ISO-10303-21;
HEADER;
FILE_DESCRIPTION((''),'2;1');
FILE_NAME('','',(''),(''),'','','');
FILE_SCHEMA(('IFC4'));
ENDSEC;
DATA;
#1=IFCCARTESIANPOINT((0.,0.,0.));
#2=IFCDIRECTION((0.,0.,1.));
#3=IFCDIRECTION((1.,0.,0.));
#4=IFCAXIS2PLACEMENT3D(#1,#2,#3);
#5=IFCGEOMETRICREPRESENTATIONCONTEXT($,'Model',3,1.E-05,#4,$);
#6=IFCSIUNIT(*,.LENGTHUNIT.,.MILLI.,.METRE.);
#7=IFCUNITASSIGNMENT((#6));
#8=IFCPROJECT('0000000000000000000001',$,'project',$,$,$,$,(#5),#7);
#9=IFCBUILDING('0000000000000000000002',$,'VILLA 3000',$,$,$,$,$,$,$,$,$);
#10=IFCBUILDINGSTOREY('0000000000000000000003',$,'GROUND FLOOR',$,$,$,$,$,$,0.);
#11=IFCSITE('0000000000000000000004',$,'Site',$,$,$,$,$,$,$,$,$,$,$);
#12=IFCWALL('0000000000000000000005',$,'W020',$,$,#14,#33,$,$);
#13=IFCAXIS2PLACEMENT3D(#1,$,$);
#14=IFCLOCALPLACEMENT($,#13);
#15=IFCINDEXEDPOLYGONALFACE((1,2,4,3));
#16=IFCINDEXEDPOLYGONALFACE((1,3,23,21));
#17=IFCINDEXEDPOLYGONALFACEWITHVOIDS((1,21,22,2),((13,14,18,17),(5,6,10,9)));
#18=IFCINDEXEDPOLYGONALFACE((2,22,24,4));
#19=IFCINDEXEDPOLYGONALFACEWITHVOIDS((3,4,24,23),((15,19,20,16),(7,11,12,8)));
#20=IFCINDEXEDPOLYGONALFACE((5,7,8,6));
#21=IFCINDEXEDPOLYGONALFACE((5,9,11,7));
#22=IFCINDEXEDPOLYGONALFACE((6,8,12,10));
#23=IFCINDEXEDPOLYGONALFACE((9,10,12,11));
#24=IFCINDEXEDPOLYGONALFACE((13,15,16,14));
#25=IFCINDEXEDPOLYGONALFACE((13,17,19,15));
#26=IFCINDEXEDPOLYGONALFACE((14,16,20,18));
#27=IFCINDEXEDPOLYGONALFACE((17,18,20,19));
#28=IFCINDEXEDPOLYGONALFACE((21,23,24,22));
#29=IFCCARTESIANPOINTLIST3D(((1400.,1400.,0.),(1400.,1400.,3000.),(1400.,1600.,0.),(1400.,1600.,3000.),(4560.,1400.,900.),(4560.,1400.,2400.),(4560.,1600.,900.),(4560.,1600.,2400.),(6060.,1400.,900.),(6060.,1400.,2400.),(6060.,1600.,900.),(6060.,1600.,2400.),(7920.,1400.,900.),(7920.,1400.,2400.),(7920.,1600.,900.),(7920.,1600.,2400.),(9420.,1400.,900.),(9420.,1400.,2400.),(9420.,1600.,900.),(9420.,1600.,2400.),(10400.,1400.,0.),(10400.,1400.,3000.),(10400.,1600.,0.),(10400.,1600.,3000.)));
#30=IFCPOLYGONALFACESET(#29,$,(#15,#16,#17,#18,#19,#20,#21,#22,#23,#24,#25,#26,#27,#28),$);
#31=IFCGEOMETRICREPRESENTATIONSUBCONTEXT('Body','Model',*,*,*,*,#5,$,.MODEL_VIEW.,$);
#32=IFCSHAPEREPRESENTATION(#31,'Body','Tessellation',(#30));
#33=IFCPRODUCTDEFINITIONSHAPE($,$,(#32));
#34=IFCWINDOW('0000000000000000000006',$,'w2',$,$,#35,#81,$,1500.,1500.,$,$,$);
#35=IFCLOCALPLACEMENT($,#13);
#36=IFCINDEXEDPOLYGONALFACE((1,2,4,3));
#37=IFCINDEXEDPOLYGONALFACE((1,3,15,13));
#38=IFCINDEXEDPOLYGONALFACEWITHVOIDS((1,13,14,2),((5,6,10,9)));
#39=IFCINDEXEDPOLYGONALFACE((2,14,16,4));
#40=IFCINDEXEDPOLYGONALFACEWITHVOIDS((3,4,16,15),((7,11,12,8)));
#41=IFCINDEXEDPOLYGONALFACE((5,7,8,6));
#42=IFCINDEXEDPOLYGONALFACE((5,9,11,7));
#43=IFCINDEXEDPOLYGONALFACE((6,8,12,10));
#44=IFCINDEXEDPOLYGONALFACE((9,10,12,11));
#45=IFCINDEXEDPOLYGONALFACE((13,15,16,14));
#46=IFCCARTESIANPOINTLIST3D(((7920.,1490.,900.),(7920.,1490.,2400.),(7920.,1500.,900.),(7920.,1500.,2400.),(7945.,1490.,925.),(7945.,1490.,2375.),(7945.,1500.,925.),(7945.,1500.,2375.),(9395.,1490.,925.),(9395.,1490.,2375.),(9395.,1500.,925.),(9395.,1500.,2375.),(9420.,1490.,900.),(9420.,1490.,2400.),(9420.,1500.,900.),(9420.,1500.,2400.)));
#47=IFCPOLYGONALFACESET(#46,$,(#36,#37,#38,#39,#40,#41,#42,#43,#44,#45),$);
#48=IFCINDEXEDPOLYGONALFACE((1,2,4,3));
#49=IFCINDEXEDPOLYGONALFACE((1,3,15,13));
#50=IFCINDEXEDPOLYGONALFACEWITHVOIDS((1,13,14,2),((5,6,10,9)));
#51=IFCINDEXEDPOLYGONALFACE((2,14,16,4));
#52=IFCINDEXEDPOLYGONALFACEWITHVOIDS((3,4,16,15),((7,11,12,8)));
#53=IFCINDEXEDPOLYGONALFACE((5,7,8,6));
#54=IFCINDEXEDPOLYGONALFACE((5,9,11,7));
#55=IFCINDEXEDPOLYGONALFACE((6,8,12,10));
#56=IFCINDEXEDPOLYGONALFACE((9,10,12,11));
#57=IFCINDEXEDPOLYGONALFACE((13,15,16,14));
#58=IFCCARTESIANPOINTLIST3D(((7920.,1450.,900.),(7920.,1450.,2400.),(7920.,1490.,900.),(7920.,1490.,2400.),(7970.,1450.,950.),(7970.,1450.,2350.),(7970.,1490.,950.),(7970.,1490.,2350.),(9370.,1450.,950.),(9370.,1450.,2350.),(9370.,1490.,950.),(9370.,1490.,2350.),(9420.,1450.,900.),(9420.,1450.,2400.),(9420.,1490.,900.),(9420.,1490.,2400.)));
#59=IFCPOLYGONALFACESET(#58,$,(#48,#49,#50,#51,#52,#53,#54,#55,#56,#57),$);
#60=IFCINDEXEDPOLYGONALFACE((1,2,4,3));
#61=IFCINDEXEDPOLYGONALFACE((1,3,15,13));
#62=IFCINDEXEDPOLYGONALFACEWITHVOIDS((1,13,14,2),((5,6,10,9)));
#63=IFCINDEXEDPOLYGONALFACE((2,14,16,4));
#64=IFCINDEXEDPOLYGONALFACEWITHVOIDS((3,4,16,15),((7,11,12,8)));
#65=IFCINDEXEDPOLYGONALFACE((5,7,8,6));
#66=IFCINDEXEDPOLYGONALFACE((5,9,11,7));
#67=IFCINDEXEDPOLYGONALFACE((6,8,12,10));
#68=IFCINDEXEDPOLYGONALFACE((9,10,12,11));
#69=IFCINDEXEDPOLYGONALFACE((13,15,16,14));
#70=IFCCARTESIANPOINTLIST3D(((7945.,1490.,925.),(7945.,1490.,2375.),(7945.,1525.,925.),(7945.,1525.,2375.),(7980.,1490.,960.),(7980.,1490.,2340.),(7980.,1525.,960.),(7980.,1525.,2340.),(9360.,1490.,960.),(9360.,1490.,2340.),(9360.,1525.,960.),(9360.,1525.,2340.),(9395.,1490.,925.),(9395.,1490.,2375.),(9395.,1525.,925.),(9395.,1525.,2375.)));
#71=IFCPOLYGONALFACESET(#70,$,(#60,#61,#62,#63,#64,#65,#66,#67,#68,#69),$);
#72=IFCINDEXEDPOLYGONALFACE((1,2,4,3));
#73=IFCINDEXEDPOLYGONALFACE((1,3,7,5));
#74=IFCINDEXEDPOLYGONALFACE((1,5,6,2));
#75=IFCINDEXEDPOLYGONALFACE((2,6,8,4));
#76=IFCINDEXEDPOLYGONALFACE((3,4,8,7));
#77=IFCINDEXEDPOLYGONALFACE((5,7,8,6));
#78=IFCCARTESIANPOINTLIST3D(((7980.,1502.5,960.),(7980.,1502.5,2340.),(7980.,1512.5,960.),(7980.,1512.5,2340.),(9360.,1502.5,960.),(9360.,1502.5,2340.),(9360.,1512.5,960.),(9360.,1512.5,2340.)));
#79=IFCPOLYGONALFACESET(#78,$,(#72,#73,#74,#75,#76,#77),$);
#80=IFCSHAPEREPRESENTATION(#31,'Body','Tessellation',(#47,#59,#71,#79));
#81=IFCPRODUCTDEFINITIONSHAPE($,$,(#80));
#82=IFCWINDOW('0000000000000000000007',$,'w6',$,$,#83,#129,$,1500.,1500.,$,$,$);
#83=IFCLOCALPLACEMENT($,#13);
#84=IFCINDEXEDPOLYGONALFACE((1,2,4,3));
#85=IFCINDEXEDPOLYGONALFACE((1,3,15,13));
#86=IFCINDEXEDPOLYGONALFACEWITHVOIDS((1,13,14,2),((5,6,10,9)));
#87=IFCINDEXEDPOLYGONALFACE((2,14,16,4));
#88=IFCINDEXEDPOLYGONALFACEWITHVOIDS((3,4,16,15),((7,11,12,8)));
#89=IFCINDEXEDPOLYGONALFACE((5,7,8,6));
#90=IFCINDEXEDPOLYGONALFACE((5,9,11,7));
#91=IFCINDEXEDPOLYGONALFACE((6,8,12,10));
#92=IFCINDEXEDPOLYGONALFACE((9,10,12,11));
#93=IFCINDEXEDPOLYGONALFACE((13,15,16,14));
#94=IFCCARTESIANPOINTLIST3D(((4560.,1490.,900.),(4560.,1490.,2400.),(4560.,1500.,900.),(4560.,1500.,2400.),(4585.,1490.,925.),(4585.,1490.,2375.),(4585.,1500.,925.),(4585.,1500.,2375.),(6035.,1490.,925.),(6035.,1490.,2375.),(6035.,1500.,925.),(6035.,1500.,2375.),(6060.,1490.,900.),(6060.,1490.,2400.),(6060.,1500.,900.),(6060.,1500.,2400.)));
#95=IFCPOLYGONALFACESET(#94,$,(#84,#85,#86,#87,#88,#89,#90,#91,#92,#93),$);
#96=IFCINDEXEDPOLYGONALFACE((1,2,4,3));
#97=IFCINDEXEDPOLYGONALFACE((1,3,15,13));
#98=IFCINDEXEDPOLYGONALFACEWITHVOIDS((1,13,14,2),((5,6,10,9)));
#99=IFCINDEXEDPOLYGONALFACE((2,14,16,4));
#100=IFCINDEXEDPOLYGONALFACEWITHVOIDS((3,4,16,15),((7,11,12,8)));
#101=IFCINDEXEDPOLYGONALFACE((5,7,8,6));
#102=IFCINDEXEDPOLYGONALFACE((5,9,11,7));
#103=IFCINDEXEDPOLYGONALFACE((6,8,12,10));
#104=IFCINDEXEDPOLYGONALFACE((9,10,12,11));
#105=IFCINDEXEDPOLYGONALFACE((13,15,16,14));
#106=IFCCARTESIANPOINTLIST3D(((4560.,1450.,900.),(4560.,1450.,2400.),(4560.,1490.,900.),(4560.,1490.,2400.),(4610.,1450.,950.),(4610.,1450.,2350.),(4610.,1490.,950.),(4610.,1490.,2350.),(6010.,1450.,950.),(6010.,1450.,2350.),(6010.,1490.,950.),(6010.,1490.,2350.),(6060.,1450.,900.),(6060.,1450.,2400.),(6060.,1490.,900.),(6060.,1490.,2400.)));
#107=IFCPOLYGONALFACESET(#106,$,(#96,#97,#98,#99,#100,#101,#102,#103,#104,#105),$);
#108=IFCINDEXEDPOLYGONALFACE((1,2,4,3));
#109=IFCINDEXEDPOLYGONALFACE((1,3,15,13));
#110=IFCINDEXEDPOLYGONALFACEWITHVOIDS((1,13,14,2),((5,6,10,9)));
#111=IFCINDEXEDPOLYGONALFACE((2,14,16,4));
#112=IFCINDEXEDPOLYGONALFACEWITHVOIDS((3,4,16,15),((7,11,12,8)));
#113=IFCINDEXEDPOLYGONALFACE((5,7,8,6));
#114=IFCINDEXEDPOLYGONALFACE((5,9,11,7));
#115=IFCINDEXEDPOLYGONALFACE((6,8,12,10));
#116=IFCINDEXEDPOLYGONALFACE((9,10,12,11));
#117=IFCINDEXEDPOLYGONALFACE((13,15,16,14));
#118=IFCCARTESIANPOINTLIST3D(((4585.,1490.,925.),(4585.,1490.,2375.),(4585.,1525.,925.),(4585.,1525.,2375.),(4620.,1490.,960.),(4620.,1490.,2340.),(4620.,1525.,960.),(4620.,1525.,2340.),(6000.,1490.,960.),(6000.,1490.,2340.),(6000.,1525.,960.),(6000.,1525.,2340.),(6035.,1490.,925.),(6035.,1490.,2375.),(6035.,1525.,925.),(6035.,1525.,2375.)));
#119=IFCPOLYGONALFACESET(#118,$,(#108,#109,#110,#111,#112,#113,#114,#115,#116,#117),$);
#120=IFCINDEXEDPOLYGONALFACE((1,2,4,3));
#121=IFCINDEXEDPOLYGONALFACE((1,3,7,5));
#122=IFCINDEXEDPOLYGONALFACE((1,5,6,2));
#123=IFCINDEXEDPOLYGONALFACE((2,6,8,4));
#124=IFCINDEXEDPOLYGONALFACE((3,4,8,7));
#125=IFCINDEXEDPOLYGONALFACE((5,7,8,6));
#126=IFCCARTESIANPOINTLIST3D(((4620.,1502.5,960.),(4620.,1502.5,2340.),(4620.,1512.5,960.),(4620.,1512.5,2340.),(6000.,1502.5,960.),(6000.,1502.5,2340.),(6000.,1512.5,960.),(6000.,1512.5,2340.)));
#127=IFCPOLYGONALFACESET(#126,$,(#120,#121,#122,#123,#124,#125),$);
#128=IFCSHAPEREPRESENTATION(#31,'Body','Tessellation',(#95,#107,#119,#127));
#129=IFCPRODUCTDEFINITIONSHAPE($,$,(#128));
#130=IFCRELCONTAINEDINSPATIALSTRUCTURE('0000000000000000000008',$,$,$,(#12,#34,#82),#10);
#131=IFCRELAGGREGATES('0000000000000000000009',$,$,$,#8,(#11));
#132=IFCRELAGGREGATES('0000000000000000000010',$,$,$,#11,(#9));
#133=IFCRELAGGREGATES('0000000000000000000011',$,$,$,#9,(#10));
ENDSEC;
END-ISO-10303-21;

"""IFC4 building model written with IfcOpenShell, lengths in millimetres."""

from ifc_helpers import new_model, si_unit, frame, origin_with_axes, place, context, subcontext, project, spatial, line, indexed_curve, outline, extrude, element, fill, save


model = new_model("IFC4")

# Units and contexts
model_context = context("Model", 3, precision=1e-05, world=origin_with_axes())
body_context = subcontext(model_context, "Body", "Model", "MODEL_VIEW")
ifc_project = project(units=[si_unit("LENGTHUNIT", "METRE", prefix="MILLI")], contexts=[model_context])

# Site, building, storey
site = spatial("IfcSite", under=ifc_project, Name="Site")
building = spatial("IfcBuilding", under=site, Name="VILLA 3000")
storey = spatial("IfcBuildingStorey", under=building, Name="GROUND FLOOR", Elevation=0.0)

# Wall, openings, windows
wall_1_placement = place(None, frame((1400.0, 1500.0, 0.0), z_axis=(0.0, 0.0, 1.0), x_axis=(1.0, 0.0, 0.0)))
wall_1 = element("IfcWall", 1, at=wall_1_placement, inside=storey, Name="W020", context=body_context, shape_type="SweptSolid", body=[
    extrude(outline(indexed_curve([(0.0, 0.0), (0.0, 200.0), (9000.0, 200.0), (9000.0, 0.0), (0.0, 0.0)], self_intersect=False)), frame((0.0, -100.0, 0.0), z_axis=(0.0, 0.0, 1.0), x_axis=(1.0, 0.0, 0.0)), (0.0, 0.0, 1.0), 3000.0),
])
opening_1_placement = place(wall_1_placement, frame((6520.0, 0.0, 900.0), z_axis=(0.0, 0.0, 1.0), x_axis=(1.0, 0.0, 0.0)))
opening_1 = element("IfcOpeningElement", 2, at=opening_1_placement, cuts=wall_1, context=body_context, shape_type="SweptSolid", body=[
    extrude(outline(indexed_curve([(0.0, 0.0), (0.0, 300.0), (1500.0, 300.0), (1500.0, 0.0), (0.0, 0.0)], self_intersect=False)), frame((0.0, -150.0, 0.0), z_axis=(0.0, 0.0, 1.0), x_axis=(1.0, 0.0, 0.0)), (0.0, 0.0, 1.0), 1500.0),
])
opening_2_placement = place(wall_1_placement, frame((3160.0, 0.0, 900.0), z_axis=(0.0, 0.0, 1.0), x_axis=(1.0, 0.0, 0.0)))
opening_2 = element("IfcOpeningElement", 3, at=opening_2_placement, cuts=wall_1, context=body_context, shape_type="SweptSolid", body=[
    extrude(outline(indexed_curve([(0.0, 0.0), (0.0, 300.0), (1500.0, 300.0), (1500.0, 0.0), (0.0, 0.0)], self_intersect=False)), frame((0.0, -150.0, 0.0), z_axis=(0.0, 0.0, 1.0), x_axis=(1.0, 0.0, 0.0)), (0.0, 0.0, 1.0), 1500.0),
])
window_1_placement = place(None, frame((7920.0, 1400.0, 900.0), z_axis=(0.0, 0.0, 1.0), x_axis=(1.0, 0.0, 0.0)))
window_1 = element("IfcWindow", 4, at=window_1_placement, inside=storey, Name="w2", OverallHeight=1500.0, OverallWidth=1500.0, context=body_context, shape_type="SweptSolid", body=[
    extrude(outline(indexed_curve([(0.0, 0.0), (1500.0, 0.0), (1500.0, 1500.0), (0.0, 1500.0)], segments=[line(1, 2, 3, 4, 1)]), holes=[indexed_curve([(25.0, 25.0), (1475.0, 25.0), (1475.0, 1475.0), (25.0, 1475.0)], segments=[line(1, 2, 3, 4, 1)])]), frame((0.0, 90.0, 0.0), z_axis=(0.0, -1.0, 0.0), x_axis=(1.0, 0.0, 0.0)), (0.0, 0.0, -1.0), 10.0),
    extrude(outline(indexed_curve([(0.0, 0.0), (1500.0, 0.0), (1500.0, 1500.0), (0.0, 1500.0)], segments=[line(1, 2, 3, 4, 1)]), holes=[indexed_curve([(50.0, 50.0), (1450.0, 50.0), (1450.0, 1450.0), (50.0, 1450.0)], segments=[line(1, 2, 3, 4, 1)])]), frame((0.0, 50.0, 0.0), z_axis=(0.0, -1.0, 0.0), x_axis=(1.0, 0.0, 0.0)), (0.0, 0.0, -1.0), 40.0),
    extrude(outline(indexed_curve([(0.0, 0.0), (1450.0, 0.0), (1450.0, 1450.0), (0.0, 1450.0)], segments=[line(1, 2, 3, 4, 1)]), holes=[indexed_curve([(35.0, 35.0), (1415.0, 35.0), (1415.0, 1415.0), (35.0, 1415.0)], segments=[line(1, 2, 3, 4, 1)])]), frame((25.0, 90.0, 25.0), z_axis=(0.0, -1.0, 0.0), x_axis=(1.0, 0.0, 0.0)), (0.0, 0.0, -1.0), 35.0),
    extrude(outline(indexed_curve([(35.0, 35.0), (1415.0, 35.0), (1415.0, 1415.0), (35.0, 1415.0)], segments=[line(1, 2, 3, 4, 1)])), frame((25.0, 102.5, 25.0), z_axis=(0.0, -1.0, 0.0), x_axis=(1.0, 0.0, 0.0)), (0.0, 0.0, -1.0), 10.0),
])
fill(opening_1, window_1)
window_2_placement = place(None, frame((4560.0, 1400.0, 900.0), z_axis=(0.0, 0.0, 1.0), x_axis=(1.0, 0.0, 0.0)))
window_2 = element("IfcWindow", 5, at=window_2_placement, inside=storey, Name="w6", OverallHeight=1500.0, OverallWidth=1500.0, context=body_context, shape_type="SweptSolid", body=[
    extrude(outline(indexed_curve([(0.0, 0.0), (1500.0, 0.0), (1500.0, 1500.0), (0.0, 1500.0)], segments=[line(1, 2, 3, 4, 1)]), holes=[indexed_curve([(25.0, 25.0), (1475.0, 25.0), (1475.0, 1475.0), (25.0, 1475.0)], segments=[line(1, 2, 3, 4, 1)])]), frame((0.0, 90.0, 0.0), z_axis=(0.0, -1.0, 0.0), x_axis=(1.0, 0.0, 0.0)), (0.0, 0.0, -1.0), 10.0),
    extrude(outline(indexed_curve([(0.0, 0.0), (1500.0, 0.0), (1500.0, 1500.0), (0.0, 1500.0)], segments=[line(1, 2, 3, 4, 1)]), holes=[indexed_curve([(50.0, 50.0), (1450.0, 50.0), (1450.0, 1450.0), (50.0, 1450.0)], segments=[line(1, 2, 3, 4, 1)])]), frame((0.0, 50.0, 0.0), z_axis=(0.0, -1.0, 0.0), x_axis=(1.0, 0.0, 0.0)), (0.0, 0.0, -1.0), 40.0),
    extrude(outline(indexed_curve([(0.0, 0.0), (1450.0, 0.0), (1450.0, 1450.0), (0.0, 1450.0)], segments=[line(1, 2, 3, 4, 1)]), holes=[indexed_curve([(35.0, 35.0), (1415.0, 35.0), (1415.0, 1415.0), (35.0, 1415.0)], segments=[line(1, 2, 3, 4, 1)])]), frame((25.0, 90.0, 25.0), z_axis=(0.0, -1.0, 0.0), x_axis=(1.0, 0.0, 0.0)), (0.0, 0.0, -1.0), 35.0),
    extrude(outline(indexed_curve([(35.0, 35.0), (1415.0, 35.0), (1415.0, 1415.0), (35.0, 1415.0)], segments=[line(1, 2, 3, 4, 1)])), frame((25.0, 102.5, 25.0), z_axis=(0.0, -1.0, 0.0), x_axis=(1.0, 0.0, 0.0)), (0.0, 0.0, -1.0), 10.0),
])
fill(opening_2, window_2)

save(model, "model.ifc")
